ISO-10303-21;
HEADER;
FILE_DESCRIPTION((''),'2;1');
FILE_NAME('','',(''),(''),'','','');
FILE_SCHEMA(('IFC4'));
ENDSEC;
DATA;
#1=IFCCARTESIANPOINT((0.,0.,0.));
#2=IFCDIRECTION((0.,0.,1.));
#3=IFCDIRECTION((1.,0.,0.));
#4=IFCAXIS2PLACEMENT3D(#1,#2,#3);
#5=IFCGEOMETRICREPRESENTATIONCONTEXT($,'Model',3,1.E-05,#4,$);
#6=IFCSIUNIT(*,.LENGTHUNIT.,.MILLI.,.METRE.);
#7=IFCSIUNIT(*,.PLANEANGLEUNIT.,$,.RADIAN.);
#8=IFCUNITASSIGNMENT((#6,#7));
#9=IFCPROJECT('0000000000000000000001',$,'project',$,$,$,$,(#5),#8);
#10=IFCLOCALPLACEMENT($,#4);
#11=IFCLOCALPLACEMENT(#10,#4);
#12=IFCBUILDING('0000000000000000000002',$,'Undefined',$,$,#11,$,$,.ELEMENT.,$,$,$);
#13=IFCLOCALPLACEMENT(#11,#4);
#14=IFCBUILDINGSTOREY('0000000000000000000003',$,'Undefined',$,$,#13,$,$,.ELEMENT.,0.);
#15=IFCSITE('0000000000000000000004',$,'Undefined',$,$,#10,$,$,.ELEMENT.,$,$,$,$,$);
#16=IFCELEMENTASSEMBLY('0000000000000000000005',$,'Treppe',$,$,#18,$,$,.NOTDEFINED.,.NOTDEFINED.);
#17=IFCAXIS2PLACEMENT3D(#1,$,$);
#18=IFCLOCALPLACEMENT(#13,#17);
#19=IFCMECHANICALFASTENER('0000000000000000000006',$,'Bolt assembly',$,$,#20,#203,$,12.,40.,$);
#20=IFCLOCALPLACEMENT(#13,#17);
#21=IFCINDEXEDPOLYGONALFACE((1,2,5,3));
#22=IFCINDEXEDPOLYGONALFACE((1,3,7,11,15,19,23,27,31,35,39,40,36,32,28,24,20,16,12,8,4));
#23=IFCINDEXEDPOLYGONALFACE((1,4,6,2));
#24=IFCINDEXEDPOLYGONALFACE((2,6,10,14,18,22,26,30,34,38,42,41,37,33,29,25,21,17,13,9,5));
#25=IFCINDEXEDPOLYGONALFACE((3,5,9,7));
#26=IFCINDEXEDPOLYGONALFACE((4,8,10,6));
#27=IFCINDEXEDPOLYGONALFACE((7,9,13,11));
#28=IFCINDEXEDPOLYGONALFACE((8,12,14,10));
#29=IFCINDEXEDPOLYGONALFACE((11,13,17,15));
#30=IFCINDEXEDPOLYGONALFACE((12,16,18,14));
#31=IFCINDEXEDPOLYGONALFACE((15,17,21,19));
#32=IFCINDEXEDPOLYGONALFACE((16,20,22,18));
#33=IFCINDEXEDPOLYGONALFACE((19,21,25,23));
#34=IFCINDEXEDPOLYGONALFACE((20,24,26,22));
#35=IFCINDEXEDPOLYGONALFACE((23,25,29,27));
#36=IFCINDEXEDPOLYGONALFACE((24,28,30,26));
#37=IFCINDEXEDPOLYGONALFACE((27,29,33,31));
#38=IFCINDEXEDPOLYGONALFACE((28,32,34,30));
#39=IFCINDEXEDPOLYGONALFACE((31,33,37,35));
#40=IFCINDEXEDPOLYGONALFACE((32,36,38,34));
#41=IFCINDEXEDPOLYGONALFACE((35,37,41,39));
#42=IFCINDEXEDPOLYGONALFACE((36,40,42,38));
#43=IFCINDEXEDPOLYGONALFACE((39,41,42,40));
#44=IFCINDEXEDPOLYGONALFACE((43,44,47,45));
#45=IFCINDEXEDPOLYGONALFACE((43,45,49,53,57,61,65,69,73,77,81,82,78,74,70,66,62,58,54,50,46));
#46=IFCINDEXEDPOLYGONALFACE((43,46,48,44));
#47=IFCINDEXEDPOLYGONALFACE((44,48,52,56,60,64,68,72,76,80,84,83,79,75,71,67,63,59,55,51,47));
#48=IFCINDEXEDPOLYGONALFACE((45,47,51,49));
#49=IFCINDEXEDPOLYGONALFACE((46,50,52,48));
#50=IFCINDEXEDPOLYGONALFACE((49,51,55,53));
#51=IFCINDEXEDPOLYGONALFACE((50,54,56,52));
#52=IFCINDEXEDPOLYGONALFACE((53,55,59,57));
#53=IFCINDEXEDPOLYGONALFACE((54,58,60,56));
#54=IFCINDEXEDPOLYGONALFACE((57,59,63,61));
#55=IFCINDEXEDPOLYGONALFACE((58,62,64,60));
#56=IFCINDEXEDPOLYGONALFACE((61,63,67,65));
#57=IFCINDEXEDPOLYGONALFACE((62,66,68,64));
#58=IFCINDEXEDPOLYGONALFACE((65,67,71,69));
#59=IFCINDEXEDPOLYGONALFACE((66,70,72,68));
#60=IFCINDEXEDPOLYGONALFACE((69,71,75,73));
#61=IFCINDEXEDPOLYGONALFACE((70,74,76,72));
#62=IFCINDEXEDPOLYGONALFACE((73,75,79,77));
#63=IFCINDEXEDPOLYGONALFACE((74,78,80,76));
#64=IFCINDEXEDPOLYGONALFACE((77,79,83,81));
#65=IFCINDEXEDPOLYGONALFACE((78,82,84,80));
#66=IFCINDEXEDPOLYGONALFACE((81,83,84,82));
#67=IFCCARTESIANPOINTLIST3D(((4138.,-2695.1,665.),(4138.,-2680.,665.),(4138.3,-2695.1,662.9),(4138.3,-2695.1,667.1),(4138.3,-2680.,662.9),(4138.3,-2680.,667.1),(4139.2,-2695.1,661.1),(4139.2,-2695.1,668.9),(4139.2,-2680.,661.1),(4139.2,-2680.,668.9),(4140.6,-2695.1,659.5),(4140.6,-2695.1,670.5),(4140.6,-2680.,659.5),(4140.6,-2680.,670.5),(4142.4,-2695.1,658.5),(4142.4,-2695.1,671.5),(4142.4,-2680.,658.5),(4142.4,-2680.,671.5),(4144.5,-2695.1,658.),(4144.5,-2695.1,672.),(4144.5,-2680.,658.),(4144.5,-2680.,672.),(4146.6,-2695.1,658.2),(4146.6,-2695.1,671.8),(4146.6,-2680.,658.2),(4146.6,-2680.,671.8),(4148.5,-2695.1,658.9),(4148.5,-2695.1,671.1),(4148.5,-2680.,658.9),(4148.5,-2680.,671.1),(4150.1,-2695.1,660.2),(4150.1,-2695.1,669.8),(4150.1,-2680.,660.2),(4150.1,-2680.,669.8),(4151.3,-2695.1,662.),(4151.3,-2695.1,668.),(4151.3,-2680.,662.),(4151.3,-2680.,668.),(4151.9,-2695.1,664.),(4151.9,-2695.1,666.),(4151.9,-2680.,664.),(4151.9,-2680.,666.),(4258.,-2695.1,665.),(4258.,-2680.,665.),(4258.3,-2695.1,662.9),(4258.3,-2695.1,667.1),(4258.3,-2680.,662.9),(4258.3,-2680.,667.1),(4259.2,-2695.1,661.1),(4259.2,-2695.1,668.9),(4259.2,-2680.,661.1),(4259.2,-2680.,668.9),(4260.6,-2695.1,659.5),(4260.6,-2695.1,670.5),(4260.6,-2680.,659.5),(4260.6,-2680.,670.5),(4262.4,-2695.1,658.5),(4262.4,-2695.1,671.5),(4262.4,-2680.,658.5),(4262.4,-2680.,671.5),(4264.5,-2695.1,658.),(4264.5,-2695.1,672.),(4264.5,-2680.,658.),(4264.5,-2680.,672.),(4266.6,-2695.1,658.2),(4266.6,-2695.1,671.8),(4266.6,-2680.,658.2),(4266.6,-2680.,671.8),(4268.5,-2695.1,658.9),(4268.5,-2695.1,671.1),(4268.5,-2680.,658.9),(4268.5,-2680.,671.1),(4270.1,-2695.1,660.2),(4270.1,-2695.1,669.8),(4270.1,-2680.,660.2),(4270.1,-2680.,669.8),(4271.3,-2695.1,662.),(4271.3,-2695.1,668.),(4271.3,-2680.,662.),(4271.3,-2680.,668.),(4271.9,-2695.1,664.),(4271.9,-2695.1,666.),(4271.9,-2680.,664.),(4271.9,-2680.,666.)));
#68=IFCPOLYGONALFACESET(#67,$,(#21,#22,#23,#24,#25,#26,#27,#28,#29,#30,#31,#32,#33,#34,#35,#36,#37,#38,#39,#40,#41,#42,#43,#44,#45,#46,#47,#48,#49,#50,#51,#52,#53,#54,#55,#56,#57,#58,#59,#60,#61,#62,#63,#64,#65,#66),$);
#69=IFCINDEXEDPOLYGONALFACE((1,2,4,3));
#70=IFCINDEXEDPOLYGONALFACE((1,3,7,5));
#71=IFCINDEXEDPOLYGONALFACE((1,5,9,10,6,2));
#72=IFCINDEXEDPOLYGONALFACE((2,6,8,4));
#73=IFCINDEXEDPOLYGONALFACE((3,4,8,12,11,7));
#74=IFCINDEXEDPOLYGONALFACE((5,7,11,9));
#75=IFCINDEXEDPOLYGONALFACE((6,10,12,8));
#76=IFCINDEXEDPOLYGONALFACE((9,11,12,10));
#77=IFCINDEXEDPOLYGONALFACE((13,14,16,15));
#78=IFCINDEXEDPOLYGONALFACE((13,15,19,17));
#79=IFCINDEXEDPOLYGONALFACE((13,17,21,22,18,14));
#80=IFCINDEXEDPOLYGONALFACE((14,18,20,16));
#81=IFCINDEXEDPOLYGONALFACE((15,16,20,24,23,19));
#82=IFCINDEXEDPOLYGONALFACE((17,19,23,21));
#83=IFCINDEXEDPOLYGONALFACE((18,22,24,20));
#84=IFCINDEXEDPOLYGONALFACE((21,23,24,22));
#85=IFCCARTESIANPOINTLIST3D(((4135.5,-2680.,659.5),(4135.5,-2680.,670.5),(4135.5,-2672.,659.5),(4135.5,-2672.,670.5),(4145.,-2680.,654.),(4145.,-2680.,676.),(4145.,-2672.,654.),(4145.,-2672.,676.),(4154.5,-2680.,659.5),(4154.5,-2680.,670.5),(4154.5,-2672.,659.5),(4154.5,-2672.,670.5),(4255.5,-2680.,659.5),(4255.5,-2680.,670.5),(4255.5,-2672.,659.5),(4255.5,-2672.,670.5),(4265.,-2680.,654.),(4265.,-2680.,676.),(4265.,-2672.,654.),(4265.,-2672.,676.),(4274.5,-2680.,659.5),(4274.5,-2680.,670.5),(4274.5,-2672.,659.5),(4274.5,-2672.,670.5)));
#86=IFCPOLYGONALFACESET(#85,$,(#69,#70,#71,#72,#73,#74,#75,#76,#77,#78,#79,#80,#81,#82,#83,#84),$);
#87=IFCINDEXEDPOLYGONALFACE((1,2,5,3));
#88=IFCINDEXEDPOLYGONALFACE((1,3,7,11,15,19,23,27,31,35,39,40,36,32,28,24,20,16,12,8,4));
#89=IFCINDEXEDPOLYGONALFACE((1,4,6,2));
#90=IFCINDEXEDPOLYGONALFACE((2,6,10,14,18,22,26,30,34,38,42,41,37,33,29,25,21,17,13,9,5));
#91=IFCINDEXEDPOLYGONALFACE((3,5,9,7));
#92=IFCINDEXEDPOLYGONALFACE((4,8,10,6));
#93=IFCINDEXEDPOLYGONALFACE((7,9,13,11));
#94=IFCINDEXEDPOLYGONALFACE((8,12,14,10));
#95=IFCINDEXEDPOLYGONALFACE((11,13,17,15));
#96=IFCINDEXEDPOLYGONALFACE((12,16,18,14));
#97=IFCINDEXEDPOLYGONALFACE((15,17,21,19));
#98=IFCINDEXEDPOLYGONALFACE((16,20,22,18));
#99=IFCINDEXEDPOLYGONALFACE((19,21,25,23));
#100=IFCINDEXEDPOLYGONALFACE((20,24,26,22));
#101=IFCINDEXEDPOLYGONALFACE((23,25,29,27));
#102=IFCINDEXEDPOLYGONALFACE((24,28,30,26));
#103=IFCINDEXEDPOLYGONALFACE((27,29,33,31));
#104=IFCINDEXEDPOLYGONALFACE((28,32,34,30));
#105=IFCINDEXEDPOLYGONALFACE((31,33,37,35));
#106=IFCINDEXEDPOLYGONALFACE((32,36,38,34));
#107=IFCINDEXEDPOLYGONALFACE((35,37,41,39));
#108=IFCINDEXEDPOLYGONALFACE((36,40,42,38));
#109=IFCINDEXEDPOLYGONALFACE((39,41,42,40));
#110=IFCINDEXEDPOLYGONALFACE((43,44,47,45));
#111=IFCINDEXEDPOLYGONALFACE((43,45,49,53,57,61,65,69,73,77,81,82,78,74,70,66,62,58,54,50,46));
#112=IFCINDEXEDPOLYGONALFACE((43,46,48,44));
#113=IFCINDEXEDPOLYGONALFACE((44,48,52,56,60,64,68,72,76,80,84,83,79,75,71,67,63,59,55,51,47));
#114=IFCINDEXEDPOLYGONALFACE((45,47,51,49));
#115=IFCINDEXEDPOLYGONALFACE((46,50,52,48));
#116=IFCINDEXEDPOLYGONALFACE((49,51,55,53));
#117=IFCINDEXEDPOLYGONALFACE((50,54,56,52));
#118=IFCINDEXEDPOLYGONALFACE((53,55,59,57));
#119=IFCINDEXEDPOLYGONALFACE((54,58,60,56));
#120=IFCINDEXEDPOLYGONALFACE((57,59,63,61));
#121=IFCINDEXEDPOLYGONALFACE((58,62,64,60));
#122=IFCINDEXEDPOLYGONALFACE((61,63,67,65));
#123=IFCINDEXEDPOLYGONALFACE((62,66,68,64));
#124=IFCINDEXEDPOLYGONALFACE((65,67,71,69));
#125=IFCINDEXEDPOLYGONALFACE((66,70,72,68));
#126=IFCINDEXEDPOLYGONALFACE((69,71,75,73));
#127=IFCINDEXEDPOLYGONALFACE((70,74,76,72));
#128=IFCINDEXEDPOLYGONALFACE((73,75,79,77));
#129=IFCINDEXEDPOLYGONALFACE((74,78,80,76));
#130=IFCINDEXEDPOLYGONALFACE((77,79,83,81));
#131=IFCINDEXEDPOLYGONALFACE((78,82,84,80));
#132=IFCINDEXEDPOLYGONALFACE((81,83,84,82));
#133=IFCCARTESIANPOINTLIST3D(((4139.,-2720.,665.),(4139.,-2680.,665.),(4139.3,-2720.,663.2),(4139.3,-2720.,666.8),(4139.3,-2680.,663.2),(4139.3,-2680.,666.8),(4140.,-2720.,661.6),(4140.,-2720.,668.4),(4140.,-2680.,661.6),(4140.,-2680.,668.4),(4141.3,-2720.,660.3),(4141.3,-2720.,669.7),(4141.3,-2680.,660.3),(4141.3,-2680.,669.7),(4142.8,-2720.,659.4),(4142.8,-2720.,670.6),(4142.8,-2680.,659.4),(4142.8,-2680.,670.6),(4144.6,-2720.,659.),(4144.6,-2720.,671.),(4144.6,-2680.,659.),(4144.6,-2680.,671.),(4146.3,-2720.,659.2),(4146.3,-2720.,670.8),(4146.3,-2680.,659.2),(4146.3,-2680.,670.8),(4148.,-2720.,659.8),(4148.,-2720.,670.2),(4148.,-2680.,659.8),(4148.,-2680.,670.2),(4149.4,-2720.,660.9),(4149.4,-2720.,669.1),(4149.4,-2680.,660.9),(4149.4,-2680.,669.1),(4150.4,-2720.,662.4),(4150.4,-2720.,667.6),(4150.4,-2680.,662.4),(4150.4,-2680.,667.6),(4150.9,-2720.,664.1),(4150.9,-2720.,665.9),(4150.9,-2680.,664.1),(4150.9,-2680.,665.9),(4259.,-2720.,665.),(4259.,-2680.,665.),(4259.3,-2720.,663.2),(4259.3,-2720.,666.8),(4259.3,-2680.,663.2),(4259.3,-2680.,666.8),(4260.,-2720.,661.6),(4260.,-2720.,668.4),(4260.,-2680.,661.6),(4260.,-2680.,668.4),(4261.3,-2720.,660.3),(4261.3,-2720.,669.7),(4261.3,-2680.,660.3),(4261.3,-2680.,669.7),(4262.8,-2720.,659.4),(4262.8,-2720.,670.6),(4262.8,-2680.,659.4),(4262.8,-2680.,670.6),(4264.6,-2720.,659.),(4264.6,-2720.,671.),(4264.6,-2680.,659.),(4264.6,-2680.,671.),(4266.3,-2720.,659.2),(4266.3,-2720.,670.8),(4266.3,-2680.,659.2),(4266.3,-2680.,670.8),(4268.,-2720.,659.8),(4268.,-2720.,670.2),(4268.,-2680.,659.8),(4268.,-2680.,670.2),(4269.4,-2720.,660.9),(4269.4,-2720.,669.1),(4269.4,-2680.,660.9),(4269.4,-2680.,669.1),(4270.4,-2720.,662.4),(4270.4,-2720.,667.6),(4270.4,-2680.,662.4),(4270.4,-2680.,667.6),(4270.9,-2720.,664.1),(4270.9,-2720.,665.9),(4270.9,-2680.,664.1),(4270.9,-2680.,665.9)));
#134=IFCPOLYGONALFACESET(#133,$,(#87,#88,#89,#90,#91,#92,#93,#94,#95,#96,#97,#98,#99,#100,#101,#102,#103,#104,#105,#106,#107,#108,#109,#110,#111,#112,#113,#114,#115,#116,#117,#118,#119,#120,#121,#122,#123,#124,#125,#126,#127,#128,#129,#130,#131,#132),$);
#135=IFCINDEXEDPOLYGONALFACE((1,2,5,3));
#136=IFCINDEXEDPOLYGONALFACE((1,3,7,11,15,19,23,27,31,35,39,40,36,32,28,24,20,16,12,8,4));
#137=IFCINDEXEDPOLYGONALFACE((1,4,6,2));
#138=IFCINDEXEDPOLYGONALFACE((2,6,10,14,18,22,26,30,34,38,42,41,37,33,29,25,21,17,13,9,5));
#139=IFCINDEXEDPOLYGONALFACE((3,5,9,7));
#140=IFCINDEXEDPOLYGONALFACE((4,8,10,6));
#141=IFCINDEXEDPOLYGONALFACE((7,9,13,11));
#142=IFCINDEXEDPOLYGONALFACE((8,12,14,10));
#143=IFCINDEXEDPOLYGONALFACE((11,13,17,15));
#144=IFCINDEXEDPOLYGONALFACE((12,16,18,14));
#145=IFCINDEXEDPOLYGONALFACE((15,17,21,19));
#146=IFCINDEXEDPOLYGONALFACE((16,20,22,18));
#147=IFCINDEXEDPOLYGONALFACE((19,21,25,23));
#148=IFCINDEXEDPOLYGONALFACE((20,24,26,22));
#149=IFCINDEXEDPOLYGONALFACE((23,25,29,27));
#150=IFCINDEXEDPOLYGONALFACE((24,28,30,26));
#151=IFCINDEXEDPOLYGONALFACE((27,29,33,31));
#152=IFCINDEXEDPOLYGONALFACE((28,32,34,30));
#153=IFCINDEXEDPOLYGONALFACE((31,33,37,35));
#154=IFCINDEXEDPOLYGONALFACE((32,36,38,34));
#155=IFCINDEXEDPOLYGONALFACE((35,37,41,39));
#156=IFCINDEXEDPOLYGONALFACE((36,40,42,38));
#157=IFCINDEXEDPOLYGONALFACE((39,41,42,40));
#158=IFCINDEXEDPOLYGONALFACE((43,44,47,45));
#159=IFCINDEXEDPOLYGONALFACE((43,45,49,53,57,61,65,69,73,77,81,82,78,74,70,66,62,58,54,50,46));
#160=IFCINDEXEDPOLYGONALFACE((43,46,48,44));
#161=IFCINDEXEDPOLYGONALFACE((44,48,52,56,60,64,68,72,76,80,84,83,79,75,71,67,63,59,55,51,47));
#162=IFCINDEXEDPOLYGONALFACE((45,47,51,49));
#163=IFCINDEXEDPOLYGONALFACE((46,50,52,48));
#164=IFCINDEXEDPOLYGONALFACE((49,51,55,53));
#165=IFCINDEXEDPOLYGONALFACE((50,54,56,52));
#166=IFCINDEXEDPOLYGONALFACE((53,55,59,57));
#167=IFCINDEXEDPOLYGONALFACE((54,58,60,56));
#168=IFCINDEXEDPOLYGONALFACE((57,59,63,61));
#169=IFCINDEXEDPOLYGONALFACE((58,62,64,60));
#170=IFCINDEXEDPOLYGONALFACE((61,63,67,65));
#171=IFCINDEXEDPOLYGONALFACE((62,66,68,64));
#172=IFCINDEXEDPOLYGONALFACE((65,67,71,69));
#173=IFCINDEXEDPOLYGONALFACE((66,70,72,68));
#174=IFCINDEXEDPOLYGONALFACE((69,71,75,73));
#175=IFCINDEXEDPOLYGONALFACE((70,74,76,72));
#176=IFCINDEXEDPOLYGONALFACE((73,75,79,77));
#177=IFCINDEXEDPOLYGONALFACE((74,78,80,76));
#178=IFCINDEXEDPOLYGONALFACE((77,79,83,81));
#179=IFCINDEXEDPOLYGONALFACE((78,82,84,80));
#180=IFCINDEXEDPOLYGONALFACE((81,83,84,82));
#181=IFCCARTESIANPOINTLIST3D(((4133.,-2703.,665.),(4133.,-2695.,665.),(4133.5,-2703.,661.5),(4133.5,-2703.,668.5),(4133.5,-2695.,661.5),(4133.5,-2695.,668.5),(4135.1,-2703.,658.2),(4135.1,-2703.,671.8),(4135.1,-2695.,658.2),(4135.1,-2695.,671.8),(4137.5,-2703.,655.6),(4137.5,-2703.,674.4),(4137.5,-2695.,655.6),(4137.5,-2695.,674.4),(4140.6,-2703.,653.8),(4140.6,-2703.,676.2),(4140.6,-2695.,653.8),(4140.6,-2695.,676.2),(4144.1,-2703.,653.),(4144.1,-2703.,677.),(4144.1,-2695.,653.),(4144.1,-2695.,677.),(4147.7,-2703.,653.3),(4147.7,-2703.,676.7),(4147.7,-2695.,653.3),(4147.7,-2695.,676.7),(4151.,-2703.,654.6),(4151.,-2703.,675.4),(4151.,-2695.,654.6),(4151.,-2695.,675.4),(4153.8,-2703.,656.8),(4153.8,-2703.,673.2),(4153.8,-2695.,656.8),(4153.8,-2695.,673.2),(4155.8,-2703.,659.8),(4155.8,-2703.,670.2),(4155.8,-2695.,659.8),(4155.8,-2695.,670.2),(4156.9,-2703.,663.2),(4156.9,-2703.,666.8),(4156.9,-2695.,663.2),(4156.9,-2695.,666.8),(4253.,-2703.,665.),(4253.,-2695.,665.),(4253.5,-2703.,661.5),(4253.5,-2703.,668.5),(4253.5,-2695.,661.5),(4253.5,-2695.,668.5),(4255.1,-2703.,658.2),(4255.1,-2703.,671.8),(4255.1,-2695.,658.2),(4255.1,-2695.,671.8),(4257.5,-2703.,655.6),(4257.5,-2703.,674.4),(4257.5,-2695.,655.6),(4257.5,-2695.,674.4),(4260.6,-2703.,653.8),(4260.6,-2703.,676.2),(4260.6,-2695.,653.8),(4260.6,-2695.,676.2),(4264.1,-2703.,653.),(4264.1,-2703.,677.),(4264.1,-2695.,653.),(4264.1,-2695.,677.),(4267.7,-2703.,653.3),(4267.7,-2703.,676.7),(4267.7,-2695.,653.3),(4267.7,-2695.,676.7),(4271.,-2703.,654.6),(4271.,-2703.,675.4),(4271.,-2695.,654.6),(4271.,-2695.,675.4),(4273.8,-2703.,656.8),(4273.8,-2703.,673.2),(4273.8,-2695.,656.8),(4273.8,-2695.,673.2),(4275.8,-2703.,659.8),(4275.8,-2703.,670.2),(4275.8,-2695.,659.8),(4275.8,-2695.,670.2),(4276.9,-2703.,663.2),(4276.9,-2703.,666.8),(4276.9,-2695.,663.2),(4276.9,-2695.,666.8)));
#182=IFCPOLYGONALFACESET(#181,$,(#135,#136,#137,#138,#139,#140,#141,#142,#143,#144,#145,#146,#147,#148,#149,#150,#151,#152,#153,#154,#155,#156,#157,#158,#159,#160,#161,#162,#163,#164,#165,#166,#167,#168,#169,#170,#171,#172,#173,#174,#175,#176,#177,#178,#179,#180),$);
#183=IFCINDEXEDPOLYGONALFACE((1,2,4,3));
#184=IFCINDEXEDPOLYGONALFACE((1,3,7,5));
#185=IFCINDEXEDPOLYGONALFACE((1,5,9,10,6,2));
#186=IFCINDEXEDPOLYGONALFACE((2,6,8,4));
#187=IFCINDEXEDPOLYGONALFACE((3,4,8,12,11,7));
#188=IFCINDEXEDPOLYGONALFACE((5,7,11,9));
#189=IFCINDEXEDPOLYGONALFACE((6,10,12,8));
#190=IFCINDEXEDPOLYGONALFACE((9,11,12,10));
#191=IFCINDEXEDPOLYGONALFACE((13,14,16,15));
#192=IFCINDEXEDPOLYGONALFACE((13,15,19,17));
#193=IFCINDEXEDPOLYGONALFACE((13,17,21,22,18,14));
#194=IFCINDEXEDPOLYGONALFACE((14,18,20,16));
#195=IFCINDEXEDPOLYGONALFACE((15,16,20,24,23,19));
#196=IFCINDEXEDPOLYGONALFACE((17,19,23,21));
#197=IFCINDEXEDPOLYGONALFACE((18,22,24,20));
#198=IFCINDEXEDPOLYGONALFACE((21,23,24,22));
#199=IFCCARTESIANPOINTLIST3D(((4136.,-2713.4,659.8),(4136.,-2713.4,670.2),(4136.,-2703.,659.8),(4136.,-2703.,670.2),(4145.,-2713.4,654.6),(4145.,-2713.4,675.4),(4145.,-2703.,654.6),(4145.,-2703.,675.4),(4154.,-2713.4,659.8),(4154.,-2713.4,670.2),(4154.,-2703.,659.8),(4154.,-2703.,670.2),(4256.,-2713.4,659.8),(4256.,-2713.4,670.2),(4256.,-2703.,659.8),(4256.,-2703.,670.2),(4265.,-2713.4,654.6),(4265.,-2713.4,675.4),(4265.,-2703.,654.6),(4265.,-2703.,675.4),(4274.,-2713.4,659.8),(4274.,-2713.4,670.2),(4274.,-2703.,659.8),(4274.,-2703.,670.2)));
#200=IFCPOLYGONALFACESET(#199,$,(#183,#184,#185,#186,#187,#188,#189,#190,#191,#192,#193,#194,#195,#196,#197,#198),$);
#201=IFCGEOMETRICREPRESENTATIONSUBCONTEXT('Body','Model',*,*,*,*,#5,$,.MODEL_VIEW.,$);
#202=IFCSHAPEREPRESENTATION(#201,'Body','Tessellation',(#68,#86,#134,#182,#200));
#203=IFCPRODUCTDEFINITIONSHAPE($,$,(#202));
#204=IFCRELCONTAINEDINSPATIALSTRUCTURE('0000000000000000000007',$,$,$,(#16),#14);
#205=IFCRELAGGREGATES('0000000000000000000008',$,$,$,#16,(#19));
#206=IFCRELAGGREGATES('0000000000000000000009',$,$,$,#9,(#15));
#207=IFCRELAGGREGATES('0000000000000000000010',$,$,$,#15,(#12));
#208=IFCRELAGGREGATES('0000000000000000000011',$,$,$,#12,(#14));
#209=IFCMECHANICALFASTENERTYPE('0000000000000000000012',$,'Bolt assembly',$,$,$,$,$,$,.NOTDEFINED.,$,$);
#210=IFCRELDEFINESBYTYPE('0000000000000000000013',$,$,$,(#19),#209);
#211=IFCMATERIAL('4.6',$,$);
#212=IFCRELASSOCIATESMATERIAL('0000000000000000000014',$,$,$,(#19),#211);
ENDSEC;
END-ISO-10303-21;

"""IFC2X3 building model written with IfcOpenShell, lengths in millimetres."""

from ifc_helpers import new_model, si_unit, frame, origin_with_axes, origin_2d_with_axis, place, context, subcontext, project, spatial, polyline, circle, outline, extrude, source, transform, mapped, material, type_object, element, aggregate, save


model = new_model("IFC2X3")

# Units and contexts
model_context = context("Model", 3, precision=1e-05, world=origin_with_axes())
body_context = subcontext(model_context, "Body", "Model", "MODEL_VIEW")
ifc_project = project(units=[si_unit("LENGTHUNIT", "METRE", prefix="MILLI"), si_unit("PLANEANGLEUNIT", "RADIAN")], contexts=[model_context])

# Site, building, storey
site_placement = place(None, origin_with_axes())
site = spatial("IfcSite", under=ifc_project, at=site_placement, Name="Undefined", CompositionType="ELEMENT")
building_placement = place(site_placement, origin_with_axes())
building = spatial("IfcBuilding", under=site, at=building_placement, Name="Undefined", CompositionType="ELEMENT")
storey_placement = place(building_placement, origin_with_axes())
storey = spatial("IfcBuildingStorey", under=building, at=storey_placement, Name="Undefined", CompositionType="ELEMENT", Elevation=0.0)

# Element assembly, mechanical fastener
ifc_material_1 = material(Name="4.6")
mechanical_fastener_type = type_object("IfcMechanicalFastenerType", Name="Bolt assembly")
assembly_1_placement = place(storey_placement, origin_with_axes())
assembly_1 = element("IfcElementAssembly", 1, at=assembly_1_placement, inside=storey, Name="Treppe", AssemblyPlace="NOTDEFINED", PredefinedType="NOTDEFINED")
shared_shape_1 = source(origin_with_axes(), body_context, "Body", "SweptSolid", [
    extrude(circle(Radius=7.0, at=origin_2d_with_axis()), frame((0.0, -15.0, 0.0), z_axis=(0.0, 1.0, 0.0), x_axis=(1.0, 0.0, 0.0)), (0.0, 0.0, 1.0), 15.1),
    extrude(outline(polyline([(9.5, -5.5), (9.5, 5.5), (0.0, 11.0), (-9.5, 5.5), (-9.5, -5.5), (0.0, -11.0), (9.5, -5.5)])), frame((0.0, -23.0, 0.0), z_axis=(0.0, 1.0, 0.0), x_axis=(1.0, 0.0, 0.0)), (0.0, 0.0, 1.0), 8.0),
    extrude(circle(Radius=6.0, at=origin_2d_with_axis()), frame((0.0, -15.0, 0.0), z_axis=(0.0, 1.0, 0.0), x_axis=(1.0, 0.0, 0.0)), (0.0, 0.0, 1.0), 40.0),
    extrude(circle(Radius=12.0, at=origin_2d_with_axis()), frame((0.0, 0.0, 0.0), z_axis=(0.0, 1.0, 0.0), x_axis=(1.0, 0.0, 0.0)), (0.0, 0.0, 1.0), 8.0),
    extrude(outline(polyline([(9.0, -5.2), (9.0, 5.2), (0.0, 10.4), (-9.0, 5.2), (-9.0, -5.2), (0.0, -10.4), (9.0, -5.2)])), frame((0.0, 8.0, 0.0), z_axis=(0.0, 1.0, 0.0), x_axis=(1.0, 0.0, 0.0)), (0.0, 0.0, 1.0), 10.4),
])
mechanical_fastener_1_placement = place(assembly_1_placement, frame((4265.0, -2695.0, 665.0), z_axis=(0.0, 0.0, 1.0), x_axis=(-1.0, 0.0, 0.0)))
mechanical_fastener_1 = element("IfcMechanicalFastener", 2, at=mechanical_fastener_1_placement, type_object=mechanical_fastener_type, material=ifc_material_1, Name="Bolt assembly", NominalDiameter=12.0, NominalLength=40.0, context=body_context, shape_type="MappedRepresentation", body=[
    mapped(shared_shape_1, transform((0.0, 0.0, 0.0))),
    mapped(shared_shape_1, transform((120.0, 0.0, 0.0))),
])
aggregate(assembly_1, [mechanical_fastener_1])

save(model, "model.ifc")
